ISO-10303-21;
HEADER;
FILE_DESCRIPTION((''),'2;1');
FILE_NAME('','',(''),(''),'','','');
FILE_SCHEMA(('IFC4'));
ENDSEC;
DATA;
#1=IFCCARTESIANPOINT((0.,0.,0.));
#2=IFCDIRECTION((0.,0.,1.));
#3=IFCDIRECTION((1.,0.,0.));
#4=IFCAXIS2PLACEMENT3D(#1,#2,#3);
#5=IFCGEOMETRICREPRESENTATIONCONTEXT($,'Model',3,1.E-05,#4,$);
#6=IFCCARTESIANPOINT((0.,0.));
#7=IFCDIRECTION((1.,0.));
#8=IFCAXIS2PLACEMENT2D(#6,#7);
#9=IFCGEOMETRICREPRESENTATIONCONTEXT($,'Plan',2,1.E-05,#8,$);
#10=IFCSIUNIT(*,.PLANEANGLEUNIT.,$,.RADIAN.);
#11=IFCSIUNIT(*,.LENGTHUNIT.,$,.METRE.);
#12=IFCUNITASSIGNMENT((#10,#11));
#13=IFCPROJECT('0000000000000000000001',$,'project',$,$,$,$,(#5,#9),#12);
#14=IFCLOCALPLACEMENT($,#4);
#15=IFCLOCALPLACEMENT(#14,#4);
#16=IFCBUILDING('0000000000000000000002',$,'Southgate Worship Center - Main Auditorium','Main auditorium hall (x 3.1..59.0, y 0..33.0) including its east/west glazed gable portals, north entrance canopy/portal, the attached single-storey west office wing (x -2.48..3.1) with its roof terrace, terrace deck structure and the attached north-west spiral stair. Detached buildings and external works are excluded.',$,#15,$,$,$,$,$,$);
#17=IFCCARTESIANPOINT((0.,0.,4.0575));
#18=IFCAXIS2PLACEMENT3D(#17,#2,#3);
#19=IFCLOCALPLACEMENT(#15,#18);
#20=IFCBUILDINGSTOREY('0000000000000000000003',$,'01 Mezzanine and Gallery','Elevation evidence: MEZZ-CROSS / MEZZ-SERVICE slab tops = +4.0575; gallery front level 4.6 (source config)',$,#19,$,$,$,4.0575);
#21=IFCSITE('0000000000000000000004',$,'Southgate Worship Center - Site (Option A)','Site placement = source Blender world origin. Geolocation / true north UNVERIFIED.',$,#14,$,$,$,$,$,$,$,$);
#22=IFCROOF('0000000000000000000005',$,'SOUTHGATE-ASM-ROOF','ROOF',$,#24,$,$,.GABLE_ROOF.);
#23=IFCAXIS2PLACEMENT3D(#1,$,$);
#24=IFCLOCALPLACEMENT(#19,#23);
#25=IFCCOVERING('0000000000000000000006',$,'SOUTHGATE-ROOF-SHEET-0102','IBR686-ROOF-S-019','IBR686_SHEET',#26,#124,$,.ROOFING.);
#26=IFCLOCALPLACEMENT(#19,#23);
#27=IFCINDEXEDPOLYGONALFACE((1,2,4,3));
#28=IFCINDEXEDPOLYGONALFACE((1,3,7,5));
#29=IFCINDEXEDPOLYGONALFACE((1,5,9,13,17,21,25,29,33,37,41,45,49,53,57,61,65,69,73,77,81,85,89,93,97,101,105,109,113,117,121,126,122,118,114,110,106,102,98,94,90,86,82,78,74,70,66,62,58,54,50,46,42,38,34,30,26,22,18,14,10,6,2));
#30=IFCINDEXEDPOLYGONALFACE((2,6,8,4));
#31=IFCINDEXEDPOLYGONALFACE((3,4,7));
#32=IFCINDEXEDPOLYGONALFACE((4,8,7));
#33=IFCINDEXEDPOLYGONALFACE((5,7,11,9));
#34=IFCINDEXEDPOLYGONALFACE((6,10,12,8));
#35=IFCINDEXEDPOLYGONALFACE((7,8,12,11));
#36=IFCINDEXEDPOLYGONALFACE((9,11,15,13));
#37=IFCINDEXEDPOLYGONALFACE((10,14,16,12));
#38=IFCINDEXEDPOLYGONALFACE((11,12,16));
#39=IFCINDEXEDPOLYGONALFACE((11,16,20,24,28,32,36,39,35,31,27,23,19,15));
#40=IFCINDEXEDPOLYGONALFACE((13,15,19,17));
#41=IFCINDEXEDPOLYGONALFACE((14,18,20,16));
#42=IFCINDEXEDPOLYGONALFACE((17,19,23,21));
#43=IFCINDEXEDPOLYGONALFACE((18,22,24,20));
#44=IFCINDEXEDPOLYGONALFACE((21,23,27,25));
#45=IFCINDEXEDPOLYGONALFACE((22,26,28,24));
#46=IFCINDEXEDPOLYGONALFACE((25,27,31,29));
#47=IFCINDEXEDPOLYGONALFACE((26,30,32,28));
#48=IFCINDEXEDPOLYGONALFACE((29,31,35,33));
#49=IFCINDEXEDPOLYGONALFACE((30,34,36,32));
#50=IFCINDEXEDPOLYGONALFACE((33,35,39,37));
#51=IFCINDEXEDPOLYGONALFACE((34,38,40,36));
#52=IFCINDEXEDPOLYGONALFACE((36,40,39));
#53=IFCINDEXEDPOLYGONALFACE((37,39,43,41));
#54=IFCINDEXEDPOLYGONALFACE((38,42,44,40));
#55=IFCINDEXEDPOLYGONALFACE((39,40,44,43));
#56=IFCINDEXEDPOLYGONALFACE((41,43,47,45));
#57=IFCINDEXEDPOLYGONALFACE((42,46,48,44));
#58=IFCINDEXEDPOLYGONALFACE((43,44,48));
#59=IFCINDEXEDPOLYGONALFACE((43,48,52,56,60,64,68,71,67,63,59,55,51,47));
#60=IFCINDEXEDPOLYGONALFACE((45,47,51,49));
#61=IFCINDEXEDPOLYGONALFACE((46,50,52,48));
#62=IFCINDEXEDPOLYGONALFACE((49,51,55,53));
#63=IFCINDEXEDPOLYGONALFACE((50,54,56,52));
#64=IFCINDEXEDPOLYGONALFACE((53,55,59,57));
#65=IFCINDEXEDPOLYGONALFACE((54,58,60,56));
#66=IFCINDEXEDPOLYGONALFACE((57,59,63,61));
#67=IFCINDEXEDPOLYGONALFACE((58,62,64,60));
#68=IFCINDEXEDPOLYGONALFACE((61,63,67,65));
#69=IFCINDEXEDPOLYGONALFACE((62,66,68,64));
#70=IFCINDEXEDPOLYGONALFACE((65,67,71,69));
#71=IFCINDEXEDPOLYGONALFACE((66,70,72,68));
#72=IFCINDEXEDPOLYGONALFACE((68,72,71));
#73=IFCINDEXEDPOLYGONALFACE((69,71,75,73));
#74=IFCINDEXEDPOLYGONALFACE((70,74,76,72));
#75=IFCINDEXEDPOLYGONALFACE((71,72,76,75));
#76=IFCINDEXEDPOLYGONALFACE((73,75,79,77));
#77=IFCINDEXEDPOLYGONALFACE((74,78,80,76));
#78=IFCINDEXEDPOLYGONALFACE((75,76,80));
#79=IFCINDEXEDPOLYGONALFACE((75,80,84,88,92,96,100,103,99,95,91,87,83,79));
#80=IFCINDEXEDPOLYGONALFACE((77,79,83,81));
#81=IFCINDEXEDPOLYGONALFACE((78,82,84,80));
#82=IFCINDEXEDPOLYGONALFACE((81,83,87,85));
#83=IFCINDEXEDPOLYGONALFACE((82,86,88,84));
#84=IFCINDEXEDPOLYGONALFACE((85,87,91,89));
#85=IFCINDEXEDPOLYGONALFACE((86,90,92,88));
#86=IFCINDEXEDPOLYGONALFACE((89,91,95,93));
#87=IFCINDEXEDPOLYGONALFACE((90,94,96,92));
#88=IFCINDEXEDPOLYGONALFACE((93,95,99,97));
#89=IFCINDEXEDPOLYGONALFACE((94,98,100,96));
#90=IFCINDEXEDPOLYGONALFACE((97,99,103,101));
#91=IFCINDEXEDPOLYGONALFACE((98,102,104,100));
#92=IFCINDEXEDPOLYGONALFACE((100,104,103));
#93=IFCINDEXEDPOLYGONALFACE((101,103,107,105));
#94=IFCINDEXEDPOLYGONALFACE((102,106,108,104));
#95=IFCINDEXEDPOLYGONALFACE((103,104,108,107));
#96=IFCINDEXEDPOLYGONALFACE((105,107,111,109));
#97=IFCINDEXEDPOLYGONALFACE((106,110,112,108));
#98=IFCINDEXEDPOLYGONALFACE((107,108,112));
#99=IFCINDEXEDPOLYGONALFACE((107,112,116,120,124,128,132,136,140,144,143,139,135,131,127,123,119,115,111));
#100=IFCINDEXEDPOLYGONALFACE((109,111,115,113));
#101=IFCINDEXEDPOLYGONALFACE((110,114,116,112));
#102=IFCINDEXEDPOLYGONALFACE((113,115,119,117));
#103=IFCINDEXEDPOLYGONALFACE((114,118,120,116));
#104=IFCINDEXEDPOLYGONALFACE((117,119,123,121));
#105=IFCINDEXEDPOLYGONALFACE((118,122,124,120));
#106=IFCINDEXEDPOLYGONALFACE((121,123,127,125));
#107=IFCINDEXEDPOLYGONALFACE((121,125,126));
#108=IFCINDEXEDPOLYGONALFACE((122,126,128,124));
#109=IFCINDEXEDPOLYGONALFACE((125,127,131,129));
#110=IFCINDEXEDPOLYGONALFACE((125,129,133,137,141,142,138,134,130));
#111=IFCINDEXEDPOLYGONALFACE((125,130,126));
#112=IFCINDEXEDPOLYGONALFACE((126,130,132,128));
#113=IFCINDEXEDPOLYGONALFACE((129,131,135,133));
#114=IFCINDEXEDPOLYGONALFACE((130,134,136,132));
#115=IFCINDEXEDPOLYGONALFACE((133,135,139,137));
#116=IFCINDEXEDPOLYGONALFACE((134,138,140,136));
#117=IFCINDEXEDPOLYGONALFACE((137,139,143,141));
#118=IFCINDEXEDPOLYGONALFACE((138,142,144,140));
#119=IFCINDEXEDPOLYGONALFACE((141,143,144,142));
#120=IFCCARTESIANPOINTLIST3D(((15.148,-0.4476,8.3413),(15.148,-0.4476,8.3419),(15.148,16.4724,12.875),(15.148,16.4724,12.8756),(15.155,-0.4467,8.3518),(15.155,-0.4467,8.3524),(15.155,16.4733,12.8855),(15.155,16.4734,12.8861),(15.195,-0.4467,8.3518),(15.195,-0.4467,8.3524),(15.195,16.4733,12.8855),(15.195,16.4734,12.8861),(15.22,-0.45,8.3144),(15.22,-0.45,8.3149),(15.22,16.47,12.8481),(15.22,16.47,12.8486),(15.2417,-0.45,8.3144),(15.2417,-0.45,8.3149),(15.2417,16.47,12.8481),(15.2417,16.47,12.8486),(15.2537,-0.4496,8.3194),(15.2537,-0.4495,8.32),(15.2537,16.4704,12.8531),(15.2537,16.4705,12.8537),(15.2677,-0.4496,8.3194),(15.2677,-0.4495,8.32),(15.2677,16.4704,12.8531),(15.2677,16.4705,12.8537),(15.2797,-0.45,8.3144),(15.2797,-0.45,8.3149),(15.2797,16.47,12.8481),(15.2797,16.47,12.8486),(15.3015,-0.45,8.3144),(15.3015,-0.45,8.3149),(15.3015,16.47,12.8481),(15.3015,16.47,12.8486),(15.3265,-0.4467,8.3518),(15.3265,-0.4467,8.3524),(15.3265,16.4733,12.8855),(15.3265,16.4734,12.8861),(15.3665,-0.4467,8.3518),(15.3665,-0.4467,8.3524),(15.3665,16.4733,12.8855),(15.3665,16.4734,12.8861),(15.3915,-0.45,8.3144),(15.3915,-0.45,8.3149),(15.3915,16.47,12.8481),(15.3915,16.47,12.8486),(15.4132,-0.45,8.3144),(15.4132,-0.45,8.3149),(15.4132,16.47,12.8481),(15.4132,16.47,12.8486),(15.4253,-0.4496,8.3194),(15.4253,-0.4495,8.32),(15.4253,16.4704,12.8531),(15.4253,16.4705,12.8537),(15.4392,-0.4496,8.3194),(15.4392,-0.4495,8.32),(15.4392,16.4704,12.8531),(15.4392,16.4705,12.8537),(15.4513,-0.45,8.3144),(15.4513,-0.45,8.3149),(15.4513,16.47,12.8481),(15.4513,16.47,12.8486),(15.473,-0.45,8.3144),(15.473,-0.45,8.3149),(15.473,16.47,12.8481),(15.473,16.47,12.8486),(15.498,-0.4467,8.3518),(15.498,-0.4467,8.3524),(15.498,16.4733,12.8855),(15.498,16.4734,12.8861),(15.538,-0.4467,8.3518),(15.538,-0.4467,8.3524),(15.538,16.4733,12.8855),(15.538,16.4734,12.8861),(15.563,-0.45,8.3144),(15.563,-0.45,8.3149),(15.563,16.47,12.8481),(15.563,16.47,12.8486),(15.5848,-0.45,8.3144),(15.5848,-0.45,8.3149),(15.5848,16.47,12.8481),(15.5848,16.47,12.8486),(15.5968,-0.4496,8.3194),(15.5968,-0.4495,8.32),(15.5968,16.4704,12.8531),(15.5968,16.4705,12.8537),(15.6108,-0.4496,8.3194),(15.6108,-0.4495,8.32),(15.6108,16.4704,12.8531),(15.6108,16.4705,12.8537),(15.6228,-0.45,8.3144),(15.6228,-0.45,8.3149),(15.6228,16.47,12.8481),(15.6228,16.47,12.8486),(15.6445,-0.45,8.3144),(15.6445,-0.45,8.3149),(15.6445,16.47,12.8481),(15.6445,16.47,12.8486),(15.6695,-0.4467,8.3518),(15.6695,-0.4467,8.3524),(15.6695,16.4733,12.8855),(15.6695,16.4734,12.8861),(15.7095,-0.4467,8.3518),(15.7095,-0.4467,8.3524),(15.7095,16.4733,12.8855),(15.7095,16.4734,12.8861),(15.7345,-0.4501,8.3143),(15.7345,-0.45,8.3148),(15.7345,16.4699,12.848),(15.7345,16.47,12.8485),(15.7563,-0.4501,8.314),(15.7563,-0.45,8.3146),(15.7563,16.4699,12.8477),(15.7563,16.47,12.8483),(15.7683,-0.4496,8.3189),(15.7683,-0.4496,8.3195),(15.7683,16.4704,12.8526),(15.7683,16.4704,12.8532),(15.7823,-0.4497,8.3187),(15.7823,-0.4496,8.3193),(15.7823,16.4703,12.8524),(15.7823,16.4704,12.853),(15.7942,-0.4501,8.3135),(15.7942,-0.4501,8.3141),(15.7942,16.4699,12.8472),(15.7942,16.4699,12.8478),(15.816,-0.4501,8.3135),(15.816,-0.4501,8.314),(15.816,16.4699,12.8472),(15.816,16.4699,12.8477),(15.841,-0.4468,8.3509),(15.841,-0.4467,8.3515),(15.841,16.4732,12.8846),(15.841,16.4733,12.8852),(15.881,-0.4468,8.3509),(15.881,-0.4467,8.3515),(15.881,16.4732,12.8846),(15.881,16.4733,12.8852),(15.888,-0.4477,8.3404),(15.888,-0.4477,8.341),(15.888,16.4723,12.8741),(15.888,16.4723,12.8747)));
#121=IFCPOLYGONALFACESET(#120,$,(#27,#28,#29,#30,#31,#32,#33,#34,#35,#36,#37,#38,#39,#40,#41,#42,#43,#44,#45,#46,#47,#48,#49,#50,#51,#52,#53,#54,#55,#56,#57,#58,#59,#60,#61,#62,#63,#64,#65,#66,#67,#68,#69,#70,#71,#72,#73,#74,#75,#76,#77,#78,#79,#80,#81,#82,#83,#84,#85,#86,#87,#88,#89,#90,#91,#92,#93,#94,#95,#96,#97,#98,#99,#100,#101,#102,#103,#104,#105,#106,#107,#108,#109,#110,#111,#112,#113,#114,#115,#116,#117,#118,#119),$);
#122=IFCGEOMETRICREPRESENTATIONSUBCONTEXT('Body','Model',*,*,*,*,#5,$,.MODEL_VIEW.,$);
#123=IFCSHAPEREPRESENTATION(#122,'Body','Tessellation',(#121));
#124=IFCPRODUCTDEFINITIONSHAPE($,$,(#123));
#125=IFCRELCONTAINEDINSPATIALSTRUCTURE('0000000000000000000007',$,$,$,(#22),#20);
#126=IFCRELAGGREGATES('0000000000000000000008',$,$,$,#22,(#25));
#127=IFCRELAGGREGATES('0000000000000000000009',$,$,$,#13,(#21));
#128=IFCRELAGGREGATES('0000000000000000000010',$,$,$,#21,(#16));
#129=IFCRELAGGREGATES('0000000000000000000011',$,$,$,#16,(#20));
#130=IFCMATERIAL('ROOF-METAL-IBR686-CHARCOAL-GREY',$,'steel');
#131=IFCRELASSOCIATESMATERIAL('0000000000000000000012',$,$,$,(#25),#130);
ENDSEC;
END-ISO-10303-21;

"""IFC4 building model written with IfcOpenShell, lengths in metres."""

from ifc_helpers import new_model, si_unit, frame, origin_with_axes, origin_2d_with_axis, place, context, subcontext, project, spatial, indexed_curve, outline, extrude, clip, halfspace, material, element, aggregate, save


model = new_model("IFC4")

# Units and contexts
model_context = context("Model", 3, precision=1e-05, world=origin_with_axes())
plan_context = context("Plan", 2, precision=1e-05, world=origin_2d_with_axis())
body_context = subcontext(model_context, "Body", "Model", "MODEL_VIEW")
ifc_project = project(units=[si_unit("PLANEANGLEUNIT", "RADIAN"), si_unit("LENGTHUNIT", "METRE")], contexts=[model_context, plan_context])

# Site, building, storey
site_placement = place(None, origin_with_axes())
site = spatial("IfcSite", under=ifc_project, at=site_placement, Name="Southgate Worship Center - Site (Option A)", Description="Site placement = source Blender world origin. Geolocation / true north UNVERIFIED.")
building_placement = place(site_placement, origin_with_axes())
building = spatial("IfcBuilding", under=site, at=building_placement, Name="Southgate Worship Center - Main Auditorium", Description="Main auditorium hall (x 3.1..59.0, y 0..33.0) including its east/west glazed gable portals, north entrance canopy/portal, the attached single-storey west office wing (x -2.48..3.1) with its roof terrace, terrace deck structure and the attached north-west spiral stair. Detached buildings and external works are excluded.")
storey_placement = place(building_placement, frame((0.0, 0.0, 4.0575), z_axis=(0.0, 0.0, 1.0), x_axis=(1.0, 0.0, 0.0)))
storey = spatial("IfcBuildingStorey", under=building, at=storey_placement, Name="01 Mezzanine and Gallery", Description="Elevation evidence: MEZZ-CROSS / MEZZ-SERVICE slab tops = +4.0575; gallery front level 4.6 (source config)", Elevation=4.0575)

# Roof, covering
roof_placement = place(storey_placement, origin_with_axes())
roof = element("IfcRoof", 1, at=roof_placement, inside=storey, Name="SOUTHGATE-ASM-ROOF", Description="ROOF", PredefinedType="GABLE_ROOF")
ifc_material_1 = material(Name="ROOF-METAL-IBR686-CHARCOAL-GREY", Category="steel")
covering_1_placement = place(roof_placement, frame((15.148, -0.4501, 8.3135), z_axis=(0.0, 0.0, 1.0), x_axis=(1.0, 0.0, 0.0)))
covering_1 = element("IfcCovering", 2, at=covering_1_placement, material=ifc_material_1, Name="SOUTHGATE-ROOF-SHEET-0102", Description="IBR686-ROOF-S-019", ObjectType="IBR686_SHEET", PredefinedType="ROOFING", context=body_context, shape_type="Clipping", body=[
    clip(clip(extrude(outline(indexed_curve([(0.0, 0.0), (0.025, 0.0353), (0.065, 0.0353), (0.072, 0.0254), (0.072, 0.0259), (0.065, 0.0358), (0.025, 0.0358), (0.0, 0.0005), (-0.0217, 0.0005), (-0.0337, 0.0053), (-0.0477, 0.0053), (-0.0597, 0.0005), (-0.0815, 0.0005), (-0.1065, 0.0358), (-0.1465, 0.0358), (-0.1715, 0.0005), (-0.1932, 0.0005), (-0.2052, 0.0053), (-0.2192, 0.0053), (-0.2312, 0.0005), (-0.253, 0.0005), (-0.278, 0.0358), (-0.318, 0.0358), (-0.343, 0.0005), (-0.3647, 0.0005), (-0.3767, 0.0053), (-0.3907, 0.0053), (-0.4028, 0.0005), (-0.4245, 0.0005), (-0.4495, 0.0358), (-0.4895, 0.0358), (-0.5145, 0.0004), (-0.5363, 0.0002), (-0.5483, 0.0048), (-0.5623, 0.0046), (-0.5742, -0.0003), (-0.596, -0.0004), (-0.621, 0.0349), (-0.661, 0.0349), (-0.668, 0.0251), (-0.668, 0.0246), (-0.661, 0.0344), (-0.621, 0.0344), (-0.596, -0.0009), (-0.5742, -0.0008), (-0.5623, 0.0041), (-0.5483, 0.0043), (-0.5363, -0.0003), (-0.5145, -0.0001), (-0.4895, 0.0353), (-0.4495, 0.0353), (-0.4245, 0.0), (-0.4028, 0.0), (-0.3907, 0.0048), (-0.3767, 0.0048), (-0.3647, 0.0), (-0.343, 0.0), (-0.318, 0.0353), (-0.278, 0.0353), (-0.253, 0.0), (-0.2312, 0.0), (-0.2192, 0.0048), (-0.2052, 0.0048), (-0.1932, 0.0), (-0.1715, 0.0), (-0.1465, 0.0353), (-0.1065, 0.0353), (-0.0815, 0.0), (-0.0597, 0.0), (-0.0477, 0.0048), (-0.0337, 0.0048), (-0.0217, 0.0), (0.0, 0.0)], self_intersect=False)), frame((0.072, -0.0003, 0.0008), z_axis=(0.0, 0.965926, 0.258819), x_axis=(-1.0, 0.0, 0.0)), (0.0, 0.0, 1.0), 17.5303), halfspace(frame((0.37, 0.0012, 0.014), z_axis=(0.0, -0.996022, 0.089113), x_axis=(1.0, 0.0, 0.0)), False)), halfspace(frame((0.37, 16.9212, 4.5477), z_axis=(0.0, 0.996021, -0.089119), x_axis=(-1.0, 0.0, 0.0)), False)),
])
aggregate(roof, [covering_1])

save(model, "model.ifc")
